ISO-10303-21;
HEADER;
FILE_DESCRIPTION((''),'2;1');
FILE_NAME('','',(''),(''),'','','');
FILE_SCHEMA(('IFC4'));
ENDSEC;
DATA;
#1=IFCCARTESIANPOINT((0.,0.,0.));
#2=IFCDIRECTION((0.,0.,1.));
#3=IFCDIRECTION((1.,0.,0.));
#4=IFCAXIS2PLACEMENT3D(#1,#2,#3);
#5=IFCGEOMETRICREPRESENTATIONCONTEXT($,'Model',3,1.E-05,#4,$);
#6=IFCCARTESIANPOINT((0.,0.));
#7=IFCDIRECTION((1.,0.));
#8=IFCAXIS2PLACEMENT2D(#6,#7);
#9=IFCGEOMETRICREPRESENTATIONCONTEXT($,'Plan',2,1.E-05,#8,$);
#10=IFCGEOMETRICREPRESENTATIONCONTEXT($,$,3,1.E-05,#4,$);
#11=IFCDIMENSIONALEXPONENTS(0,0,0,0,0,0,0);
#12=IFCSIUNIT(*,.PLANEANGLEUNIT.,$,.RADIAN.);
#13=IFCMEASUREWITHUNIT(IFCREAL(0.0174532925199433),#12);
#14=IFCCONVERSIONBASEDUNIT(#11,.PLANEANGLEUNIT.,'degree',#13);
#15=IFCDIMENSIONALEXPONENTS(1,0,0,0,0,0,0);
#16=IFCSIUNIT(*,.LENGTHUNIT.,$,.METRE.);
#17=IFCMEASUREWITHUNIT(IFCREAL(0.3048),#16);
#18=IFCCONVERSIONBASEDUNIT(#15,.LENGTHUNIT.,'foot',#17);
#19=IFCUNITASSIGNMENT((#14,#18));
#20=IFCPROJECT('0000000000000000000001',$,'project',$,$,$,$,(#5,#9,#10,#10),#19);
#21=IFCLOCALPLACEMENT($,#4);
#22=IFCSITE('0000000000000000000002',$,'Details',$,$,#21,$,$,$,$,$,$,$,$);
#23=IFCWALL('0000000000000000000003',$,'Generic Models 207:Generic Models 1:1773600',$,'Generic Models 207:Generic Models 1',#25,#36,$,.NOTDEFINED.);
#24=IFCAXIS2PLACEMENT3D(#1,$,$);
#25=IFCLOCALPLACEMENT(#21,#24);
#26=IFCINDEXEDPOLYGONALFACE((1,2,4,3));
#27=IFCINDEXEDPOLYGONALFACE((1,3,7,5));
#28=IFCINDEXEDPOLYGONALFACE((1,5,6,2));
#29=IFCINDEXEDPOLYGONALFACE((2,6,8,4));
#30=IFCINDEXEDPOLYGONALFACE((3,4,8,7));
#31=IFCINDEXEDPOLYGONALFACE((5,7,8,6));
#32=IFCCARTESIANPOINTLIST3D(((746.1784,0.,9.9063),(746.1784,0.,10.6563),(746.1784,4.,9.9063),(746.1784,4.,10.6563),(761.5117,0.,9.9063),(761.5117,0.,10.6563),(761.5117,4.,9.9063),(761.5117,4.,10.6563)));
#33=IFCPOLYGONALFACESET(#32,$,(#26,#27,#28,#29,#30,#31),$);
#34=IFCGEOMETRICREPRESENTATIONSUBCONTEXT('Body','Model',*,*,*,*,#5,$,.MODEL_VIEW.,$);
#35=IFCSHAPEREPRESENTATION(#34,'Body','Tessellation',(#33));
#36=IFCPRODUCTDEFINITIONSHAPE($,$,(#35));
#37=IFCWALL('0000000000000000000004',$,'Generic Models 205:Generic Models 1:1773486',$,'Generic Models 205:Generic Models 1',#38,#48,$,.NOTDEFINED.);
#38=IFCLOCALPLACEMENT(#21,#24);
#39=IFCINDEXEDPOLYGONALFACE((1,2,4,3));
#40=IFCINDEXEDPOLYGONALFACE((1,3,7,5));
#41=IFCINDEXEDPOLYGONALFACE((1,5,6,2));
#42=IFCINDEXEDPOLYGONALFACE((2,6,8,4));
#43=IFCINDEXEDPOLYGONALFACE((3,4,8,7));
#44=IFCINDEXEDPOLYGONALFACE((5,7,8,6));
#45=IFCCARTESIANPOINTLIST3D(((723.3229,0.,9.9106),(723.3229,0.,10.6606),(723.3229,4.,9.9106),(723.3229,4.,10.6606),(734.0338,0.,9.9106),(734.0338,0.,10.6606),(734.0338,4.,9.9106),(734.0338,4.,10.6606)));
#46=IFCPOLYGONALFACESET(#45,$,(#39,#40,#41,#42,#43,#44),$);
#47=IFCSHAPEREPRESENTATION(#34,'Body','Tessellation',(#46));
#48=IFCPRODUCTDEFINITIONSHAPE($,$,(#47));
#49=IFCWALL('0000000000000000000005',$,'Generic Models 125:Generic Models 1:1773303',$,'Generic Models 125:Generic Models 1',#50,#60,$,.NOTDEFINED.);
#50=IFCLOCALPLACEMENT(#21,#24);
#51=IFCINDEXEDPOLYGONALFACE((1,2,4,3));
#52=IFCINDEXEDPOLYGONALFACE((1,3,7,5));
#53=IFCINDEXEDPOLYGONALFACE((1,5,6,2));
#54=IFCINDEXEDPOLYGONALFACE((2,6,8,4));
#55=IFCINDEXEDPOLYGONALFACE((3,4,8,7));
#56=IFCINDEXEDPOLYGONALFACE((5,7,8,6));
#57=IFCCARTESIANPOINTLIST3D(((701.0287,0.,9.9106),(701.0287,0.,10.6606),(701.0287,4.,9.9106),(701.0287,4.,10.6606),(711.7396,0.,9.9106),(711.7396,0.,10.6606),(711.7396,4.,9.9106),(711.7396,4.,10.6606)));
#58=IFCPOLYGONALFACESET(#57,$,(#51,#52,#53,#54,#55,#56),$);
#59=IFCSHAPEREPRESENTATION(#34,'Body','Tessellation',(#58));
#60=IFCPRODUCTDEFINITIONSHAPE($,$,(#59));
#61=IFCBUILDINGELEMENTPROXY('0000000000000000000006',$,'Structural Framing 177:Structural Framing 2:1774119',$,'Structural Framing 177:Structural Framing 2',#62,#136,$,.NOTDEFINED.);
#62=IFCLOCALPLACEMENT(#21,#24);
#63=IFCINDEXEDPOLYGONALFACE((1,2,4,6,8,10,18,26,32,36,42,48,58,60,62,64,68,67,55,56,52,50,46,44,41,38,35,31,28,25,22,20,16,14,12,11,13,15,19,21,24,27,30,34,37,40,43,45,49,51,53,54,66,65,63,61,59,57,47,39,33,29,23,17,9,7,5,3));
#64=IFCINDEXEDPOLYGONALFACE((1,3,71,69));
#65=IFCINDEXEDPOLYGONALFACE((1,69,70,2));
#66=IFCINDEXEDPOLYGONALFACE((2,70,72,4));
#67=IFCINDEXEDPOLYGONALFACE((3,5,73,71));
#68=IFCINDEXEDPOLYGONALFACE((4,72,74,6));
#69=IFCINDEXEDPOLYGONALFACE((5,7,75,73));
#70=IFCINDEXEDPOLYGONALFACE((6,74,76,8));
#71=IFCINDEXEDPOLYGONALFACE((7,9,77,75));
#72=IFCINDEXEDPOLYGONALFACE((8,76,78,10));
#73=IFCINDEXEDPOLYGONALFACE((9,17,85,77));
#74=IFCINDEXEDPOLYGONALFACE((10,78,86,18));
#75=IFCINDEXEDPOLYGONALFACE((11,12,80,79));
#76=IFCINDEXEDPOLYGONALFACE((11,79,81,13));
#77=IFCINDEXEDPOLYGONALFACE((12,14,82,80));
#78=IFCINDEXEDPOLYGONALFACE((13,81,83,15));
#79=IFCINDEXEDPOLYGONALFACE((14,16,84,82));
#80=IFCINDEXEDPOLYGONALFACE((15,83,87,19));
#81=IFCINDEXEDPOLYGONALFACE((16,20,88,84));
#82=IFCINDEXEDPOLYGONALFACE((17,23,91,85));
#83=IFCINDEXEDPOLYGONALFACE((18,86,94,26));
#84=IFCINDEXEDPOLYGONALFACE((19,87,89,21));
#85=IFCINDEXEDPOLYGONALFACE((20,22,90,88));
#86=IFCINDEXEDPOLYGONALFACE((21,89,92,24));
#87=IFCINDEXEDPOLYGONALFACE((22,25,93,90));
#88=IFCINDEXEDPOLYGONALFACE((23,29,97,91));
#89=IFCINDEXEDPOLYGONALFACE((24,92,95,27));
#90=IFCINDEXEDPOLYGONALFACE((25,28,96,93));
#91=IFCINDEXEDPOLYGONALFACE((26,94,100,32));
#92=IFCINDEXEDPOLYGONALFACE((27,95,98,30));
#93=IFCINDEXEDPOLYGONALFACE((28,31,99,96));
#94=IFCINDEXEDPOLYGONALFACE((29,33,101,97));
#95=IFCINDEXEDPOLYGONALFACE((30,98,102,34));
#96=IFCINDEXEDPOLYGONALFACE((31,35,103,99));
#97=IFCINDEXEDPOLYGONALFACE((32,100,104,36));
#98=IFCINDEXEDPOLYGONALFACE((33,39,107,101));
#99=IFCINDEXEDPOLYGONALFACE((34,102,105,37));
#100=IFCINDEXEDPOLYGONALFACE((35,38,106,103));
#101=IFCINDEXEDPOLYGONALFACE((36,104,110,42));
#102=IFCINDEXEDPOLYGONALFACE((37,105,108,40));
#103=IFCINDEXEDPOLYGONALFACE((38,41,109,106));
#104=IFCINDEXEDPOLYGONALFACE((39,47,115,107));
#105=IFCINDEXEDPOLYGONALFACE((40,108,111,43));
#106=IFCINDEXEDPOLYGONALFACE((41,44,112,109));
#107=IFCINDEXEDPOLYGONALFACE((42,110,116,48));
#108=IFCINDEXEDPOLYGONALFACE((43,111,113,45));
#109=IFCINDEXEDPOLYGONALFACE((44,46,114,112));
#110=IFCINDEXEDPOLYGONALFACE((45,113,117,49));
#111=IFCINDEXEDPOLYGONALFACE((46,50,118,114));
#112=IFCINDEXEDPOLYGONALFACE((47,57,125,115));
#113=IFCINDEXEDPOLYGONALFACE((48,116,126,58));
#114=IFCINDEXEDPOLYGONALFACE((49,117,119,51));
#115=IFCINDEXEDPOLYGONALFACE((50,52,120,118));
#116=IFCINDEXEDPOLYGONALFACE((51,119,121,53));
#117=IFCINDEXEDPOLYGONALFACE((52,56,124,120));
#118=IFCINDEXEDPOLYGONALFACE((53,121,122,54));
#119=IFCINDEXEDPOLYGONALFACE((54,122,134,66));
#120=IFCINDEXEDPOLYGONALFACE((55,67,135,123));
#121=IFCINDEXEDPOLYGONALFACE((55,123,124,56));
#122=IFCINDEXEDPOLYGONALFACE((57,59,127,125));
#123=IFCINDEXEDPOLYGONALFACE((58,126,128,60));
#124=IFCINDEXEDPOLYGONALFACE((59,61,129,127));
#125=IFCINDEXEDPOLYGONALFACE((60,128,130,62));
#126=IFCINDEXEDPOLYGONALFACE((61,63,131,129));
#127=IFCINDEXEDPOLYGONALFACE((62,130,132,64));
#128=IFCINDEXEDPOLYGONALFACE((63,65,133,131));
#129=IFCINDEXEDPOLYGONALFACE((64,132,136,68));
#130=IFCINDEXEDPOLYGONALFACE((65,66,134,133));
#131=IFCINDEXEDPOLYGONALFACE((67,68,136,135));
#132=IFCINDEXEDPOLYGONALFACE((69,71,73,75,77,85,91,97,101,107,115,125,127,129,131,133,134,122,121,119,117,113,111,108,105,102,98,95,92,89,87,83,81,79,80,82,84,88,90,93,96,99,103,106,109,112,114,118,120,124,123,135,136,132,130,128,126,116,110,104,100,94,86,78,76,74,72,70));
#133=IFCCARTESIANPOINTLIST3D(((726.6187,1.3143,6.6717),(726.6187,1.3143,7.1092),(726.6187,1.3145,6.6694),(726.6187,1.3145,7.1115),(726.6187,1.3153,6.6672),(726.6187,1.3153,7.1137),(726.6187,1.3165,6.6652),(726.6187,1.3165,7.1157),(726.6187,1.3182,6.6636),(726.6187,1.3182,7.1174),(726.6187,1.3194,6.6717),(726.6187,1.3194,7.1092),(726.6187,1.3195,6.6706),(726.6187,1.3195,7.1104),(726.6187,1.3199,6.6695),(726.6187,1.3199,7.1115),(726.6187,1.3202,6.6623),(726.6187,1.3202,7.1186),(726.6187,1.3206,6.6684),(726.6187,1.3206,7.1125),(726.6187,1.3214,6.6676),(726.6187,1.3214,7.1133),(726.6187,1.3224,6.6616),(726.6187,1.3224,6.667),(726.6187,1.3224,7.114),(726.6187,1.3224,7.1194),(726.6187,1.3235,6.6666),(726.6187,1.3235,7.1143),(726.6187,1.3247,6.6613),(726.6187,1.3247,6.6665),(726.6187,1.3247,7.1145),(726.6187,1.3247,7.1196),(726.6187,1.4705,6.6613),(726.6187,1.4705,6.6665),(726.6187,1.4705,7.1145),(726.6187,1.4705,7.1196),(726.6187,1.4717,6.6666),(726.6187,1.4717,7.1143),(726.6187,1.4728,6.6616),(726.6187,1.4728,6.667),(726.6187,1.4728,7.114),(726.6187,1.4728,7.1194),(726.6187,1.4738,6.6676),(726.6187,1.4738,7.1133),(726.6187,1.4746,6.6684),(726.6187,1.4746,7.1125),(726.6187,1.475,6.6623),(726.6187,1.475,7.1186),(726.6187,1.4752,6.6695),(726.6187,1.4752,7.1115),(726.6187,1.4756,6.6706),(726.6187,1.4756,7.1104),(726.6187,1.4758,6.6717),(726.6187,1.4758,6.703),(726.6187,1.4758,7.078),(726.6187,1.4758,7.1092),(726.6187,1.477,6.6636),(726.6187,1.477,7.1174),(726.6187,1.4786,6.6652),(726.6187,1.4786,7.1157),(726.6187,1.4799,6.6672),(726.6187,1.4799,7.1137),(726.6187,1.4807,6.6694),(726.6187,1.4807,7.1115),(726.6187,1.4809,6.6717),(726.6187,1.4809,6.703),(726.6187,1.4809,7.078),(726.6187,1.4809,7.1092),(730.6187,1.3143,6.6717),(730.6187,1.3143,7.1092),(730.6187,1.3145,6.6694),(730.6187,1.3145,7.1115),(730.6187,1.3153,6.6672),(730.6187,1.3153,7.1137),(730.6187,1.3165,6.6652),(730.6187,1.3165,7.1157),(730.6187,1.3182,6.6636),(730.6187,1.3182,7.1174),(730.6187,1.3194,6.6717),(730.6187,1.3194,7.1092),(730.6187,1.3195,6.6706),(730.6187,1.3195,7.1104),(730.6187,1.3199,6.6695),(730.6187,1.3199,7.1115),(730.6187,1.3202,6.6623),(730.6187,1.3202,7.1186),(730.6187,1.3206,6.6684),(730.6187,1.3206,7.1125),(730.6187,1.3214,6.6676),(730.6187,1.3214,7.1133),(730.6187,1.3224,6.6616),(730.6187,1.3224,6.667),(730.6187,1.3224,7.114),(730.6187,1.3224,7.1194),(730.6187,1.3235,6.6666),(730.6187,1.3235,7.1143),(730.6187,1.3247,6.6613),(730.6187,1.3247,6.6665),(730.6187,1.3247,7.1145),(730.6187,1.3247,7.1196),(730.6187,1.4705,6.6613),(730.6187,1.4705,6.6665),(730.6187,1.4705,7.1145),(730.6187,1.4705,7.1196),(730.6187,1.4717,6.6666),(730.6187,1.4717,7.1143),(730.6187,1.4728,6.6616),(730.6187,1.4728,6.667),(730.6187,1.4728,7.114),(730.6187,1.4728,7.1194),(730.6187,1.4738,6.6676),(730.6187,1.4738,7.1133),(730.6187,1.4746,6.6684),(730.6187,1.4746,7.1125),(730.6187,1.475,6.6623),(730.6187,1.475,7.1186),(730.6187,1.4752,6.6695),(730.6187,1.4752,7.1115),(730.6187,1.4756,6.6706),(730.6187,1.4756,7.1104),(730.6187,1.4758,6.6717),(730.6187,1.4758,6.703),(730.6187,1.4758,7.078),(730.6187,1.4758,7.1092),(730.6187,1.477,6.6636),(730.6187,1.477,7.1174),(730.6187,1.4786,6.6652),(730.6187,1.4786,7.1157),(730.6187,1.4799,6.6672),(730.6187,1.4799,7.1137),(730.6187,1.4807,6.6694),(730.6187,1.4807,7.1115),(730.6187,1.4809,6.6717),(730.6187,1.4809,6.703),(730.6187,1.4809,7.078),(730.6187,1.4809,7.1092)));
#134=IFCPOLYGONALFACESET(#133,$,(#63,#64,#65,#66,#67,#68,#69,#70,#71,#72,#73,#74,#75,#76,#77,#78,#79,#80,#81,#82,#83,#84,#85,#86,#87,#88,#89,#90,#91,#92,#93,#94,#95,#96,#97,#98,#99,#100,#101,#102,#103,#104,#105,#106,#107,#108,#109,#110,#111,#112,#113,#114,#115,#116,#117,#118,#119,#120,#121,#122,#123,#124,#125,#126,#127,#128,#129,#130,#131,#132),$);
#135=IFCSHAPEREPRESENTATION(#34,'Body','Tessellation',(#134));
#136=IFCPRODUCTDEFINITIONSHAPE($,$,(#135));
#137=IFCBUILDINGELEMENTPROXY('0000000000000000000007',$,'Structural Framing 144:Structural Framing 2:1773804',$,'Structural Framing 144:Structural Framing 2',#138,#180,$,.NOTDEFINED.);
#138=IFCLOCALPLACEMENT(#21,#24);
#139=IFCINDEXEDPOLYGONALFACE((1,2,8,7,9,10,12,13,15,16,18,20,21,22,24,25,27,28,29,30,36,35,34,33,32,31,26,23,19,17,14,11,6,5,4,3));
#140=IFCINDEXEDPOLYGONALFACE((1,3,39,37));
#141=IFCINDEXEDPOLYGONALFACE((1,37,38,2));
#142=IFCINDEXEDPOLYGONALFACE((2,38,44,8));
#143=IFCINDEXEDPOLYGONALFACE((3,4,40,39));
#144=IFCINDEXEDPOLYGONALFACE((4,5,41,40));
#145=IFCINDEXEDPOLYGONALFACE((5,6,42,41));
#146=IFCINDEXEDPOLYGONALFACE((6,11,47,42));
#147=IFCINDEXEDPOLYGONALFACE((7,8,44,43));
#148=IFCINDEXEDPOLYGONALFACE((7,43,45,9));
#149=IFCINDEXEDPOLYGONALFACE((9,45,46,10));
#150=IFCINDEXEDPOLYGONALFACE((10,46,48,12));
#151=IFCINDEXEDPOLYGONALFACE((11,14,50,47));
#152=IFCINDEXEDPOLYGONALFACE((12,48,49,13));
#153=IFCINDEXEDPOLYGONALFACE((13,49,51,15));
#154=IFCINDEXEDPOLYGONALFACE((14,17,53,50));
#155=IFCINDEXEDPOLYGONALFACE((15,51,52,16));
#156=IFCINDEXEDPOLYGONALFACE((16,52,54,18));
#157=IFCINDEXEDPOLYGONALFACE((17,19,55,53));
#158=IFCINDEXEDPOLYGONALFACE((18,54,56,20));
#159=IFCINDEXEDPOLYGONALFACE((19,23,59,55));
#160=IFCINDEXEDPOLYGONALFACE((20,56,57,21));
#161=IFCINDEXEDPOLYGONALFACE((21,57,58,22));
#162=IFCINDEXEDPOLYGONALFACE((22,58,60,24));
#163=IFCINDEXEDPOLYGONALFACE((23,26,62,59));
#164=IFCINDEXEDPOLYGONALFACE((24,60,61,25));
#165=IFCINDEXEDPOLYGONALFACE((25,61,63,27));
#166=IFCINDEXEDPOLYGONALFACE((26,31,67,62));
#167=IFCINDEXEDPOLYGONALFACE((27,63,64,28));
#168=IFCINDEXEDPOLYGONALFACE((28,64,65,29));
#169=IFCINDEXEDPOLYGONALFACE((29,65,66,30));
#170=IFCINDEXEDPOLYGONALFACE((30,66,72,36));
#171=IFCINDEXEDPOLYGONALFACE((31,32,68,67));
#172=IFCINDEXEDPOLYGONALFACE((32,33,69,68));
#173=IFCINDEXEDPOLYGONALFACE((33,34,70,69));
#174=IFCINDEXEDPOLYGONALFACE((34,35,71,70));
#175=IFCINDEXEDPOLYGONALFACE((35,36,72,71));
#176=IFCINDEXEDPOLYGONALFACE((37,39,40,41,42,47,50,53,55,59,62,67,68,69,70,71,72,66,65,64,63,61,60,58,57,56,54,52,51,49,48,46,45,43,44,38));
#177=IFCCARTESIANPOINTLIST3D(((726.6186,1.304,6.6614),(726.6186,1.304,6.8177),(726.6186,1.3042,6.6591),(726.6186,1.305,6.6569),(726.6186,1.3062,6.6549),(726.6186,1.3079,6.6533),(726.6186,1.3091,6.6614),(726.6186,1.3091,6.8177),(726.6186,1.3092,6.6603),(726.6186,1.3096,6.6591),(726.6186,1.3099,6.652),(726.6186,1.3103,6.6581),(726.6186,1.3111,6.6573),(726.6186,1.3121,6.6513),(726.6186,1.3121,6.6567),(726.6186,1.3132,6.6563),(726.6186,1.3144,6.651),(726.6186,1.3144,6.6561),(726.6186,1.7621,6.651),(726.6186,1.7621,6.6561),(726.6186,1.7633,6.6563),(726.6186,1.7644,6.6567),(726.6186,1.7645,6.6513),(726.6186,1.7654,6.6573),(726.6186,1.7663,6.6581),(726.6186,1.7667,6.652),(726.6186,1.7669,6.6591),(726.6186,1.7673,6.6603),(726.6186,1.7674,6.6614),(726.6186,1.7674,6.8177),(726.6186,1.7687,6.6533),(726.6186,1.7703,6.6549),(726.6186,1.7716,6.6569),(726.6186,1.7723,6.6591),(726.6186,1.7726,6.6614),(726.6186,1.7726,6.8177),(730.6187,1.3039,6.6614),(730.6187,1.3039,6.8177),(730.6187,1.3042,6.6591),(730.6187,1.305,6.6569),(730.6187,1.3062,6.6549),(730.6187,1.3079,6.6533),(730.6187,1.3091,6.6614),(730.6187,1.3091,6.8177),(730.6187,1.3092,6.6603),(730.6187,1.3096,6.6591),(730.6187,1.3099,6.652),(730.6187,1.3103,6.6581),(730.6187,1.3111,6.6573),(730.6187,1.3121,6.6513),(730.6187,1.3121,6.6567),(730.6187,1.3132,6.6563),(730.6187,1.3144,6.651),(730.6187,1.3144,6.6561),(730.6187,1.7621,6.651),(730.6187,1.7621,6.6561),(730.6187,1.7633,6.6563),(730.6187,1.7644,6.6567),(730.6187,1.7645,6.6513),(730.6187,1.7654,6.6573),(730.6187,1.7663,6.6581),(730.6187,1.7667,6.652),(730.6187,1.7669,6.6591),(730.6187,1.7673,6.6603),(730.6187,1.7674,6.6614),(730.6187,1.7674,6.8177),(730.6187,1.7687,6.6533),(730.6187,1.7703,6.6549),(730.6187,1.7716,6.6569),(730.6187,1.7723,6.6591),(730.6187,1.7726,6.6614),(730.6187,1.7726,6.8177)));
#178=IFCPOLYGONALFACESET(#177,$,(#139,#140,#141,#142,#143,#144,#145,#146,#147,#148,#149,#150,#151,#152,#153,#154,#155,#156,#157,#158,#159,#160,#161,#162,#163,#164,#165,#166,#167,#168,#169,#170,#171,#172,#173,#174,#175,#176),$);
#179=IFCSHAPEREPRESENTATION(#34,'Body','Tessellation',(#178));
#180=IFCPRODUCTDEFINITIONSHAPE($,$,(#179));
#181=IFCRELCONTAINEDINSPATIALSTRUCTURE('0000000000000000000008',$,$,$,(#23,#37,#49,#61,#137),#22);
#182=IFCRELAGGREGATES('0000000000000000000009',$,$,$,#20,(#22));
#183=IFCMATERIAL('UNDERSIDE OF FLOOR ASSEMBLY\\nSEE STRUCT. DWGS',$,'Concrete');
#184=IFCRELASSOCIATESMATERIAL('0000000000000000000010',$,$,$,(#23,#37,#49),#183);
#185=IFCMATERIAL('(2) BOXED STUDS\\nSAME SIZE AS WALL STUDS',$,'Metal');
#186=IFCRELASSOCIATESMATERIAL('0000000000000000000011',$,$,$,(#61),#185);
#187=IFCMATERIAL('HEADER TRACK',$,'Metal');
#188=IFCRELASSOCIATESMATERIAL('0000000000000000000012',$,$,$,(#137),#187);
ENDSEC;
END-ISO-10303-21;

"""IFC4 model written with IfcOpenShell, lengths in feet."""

from ifc_helpers import new_model, entity, si_unit, converted_unit, frame, origin_with_axes, origin_2d_with_axis, place, context, subcontext, project, spatial, polyline, rectangle, outline, extrude, material, element, save


model = new_model("IFC4")

# Units and contexts
model_context = context("Model", 3, precision=1e-05, world=origin_with_axes())
plan_context = context("Plan", 2, precision=1e-05, world=origin_2d_with_axis())
context_of_model = context(None, 3, precision=1e-05, world=origin_with_axes())
body_context = subcontext(model_context, "Body", "Model", "MODEL_VIEW")
ifc_project = project(units=[converted_unit("PLANEANGLEUNIT", "degree", entity("IfcReal", 0.0174532925199433), si_unit("PLANEANGLEUNIT", "RADIAN"), dimensions=[0, 0, 0, 0, 0, 0, 0]), converted_unit("LENGTHUNIT", "foot", entity("IfcReal", 0.3048), si_unit("LENGTHUNIT", "METRE"), dimensions=[1, 0, 0, 0, 0, 0, 0])], contexts=[model_context, plan_context, context_of_model, context_of_model])

# Site
site_placement = place(None, origin_with_axes())
site = spatial("IfcSite", under=ifc_project, at=site_placement, Name="Details")

# Walls
ifc_material_1 = material(Name="UNDERSIDE OF FLOOR ASSEMBLY\\nSEE STRUCT. DWGS", Category="Concrete")
wall_1_placement = place(site_placement, frame((746.1784, 0.0, 9.9063), z_axis=(0.0, 0.0, 1.0), x_axis=(1.0, 0.0, 0.0)))
element("IfcWall", 1, at=wall_1_placement, inside=site, material=ifc_material_1, Name="Generic Models 207:Generic Models 1:1773600", ObjectType="Generic Models 207:Generic Models 1", PredefinedType="NOTDEFINED", context=body_context, shape_type="SweptSolid", body=[
    extrude(rectangle(XDim=4.0, YDim=15.3333, at=origin_2d_with_axis()), frame((7.6667, 2.0, 0.0), z_axis=(0.0, 0.0, 1.0), x_axis=(0.0, 1.0, 0.0)), (0.0, 0.0, 1.0), 0.75),
])
wall_2_placement = place(site_placement, frame((723.3229, 0.0, 9.9106), z_axis=(0.0, 0.0, 1.0), x_axis=(1.0, 0.0, 0.0)))
element("IfcWall", 2, at=wall_2_placement, inside=site, material=ifc_material_1, Name="Generic Models 205:Generic Models 1:1773486", ObjectType="Generic Models 205:Generic Models 1", PredefinedType="NOTDEFINED", context=body_context, shape_type="SweptSolid", body=[
    extrude(rectangle(XDim=4.0, YDim=10.7109, at=origin_2d_with_axis()), frame((5.3554, 2.0, 0.0), z_axis=(0.0, 0.0, 1.0), x_axis=(0.0, 1.0, 0.0)), (0.0, 0.0, 1.0), 0.75),
])
wall_3_placement = place(site_placement, frame((701.0287, 0.0, 9.9106), z_axis=(0.0, 0.0, 1.0), x_axis=(1.0, 0.0, 0.0)))
element("IfcWall", 3, at=wall_3_placement, inside=site, material=ifc_material_1, Name="Generic Models 125:Generic Models 1:1773303", ObjectType="Generic Models 125:Generic Models 1", PredefinedType="NOTDEFINED", context=body_context, shape_type="SweptSolid", body=[
    extrude(rectangle(XDim=4.0, YDim=10.7109, at=origin_2d_with_axis()), frame((5.3554, 2.0, 0.0), z_axis=(0.0, 0.0, 1.0), x_axis=(0.0, 1.0, 0.0)), (0.0, 0.0, 1.0), 0.75),
])

# Building element proxies
ifc_material_2 = material(Name="HEADER TRACK", Category="Metal")
ifc_material_3 = material(Name="(2) BOXED STUDS\\nSAME SIZE AS WALL STUDS", Category="Metal")
proxy_1_placement = place(site_placement, frame((728.6186, 1.3616, 6.8905), z_axis=(1.0, 0.0, 0.0), x_axis=(0.0, 0.0, -1.0)))
element("IfcBuildingElementProxy", 4, at=proxy_1_placement, inside=site, material=ifc_material_3, Name="Structural Framing 177:Structural Framing 2:1774119", ObjectType="Structural Framing 177:Structural Framing 2", PredefinedType="NOTDEFINED", context=body_context, shape_type="SweptSolid", body=[
    extrude(outline(polyline([(-0.0681, 0.224), (0.0776, 0.224), (0.0788, 0.2239), (0.0799, 0.2235), (0.0809, 0.2229), (0.0818, 0.222), (0.0824, 0.221), (0.0828, 0.2199), (0.0829, 0.2187), (0.0829, -0.2187), (0.0828, -0.2199), (0.0824, -0.221), (0.0818, -0.222), (0.0809, -0.2229), (0.0799, -0.2235), (0.0788, -0.2239), (0.0776, -0.224), (-0.0681, -0.224), (-0.0693, -0.2239), (-0.0704, -0.2235), (-0.0714, -0.2229), (-0.0723, -0.222), (-0.0729, -0.221), (-0.0733, -0.2199), (-0.0734, -0.2187), (-0.0734, -0.1875), (-0.0786, -0.1875), (-0.0786, -0.2187), (-0.0783, -0.221), (-0.0775, -0.2233), (-0.0763, -0.2252), (-0.0746, -0.2269), (-0.0727, -0.2281), (-0.0705, -0.2289), (-0.0681, -0.2292), (0.0776, -0.2292), (0.08, -0.2289), (0.0822, -0.2281), (0.0842, -0.2269), (0.0858, -0.2252), (0.087, -0.2233), (0.0878, -0.221), (0.0881, -0.2187), (0.0881, 0.2187), (0.0878, 0.221), (0.087, 0.2233), (0.0858, 0.2252), (0.0842, 0.2269), (0.0822, 0.2281), (0.08, 0.2289), (0.0776, 0.2292), (-0.0681, 0.2292), (-0.0705, 0.2289), (-0.0727, 0.2281), (-0.0746, 0.2269), (-0.0763, 0.2252), (-0.0775, 0.2233), (-0.0783, 0.221), (-0.0786, 0.2187), (-0.0786, 0.1875), (-0.0734, 0.1875), (-0.0734, 0.2187), (-0.0733, 0.2199), (-0.0729, 0.221), (-0.0723, 0.222), (-0.0714, 0.2229), (-0.0704, 0.2235), (-0.0693, 0.2239), (-0.0681, 0.224)])), frame((0.0, 0.0408, -2.0), z_axis=(0.000001, 0.0, -1.0), x_axis=(0.0, -1.0, 0.0)), (0.0, -0.000001, -1.0), 4.0),
])
proxy_2_placement = place(site_placement, frame((728.6187, 1.5383, 6.6879), z_axis=(1.0, 0.0, 0.0), x_axis=(0.0, 0.0, -1.0)))
element("IfcBuildingElementProxy", 5, at=proxy_2_placement, inside=site, material=ifc_material_2, Name="Structural Framing 144:Structural Framing 2:1773804", ObjectType="Structural Framing 144:Structural Framing 2", PredefinedType="NOTDEFINED", context=body_context, shape_type="SweptSolid", body=[
    extrude(outline(polyline([(0.2269, 0.0), (0.2258, -0.0005), (0.2246, -0.0007), (-0.2217, -0.0359), (-0.2229, -0.0358), (-0.2241, -0.0355), (-0.2251, -0.035), (-0.226, -0.0342), (-0.2267, -0.0332), (-0.2272, -0.0322), (-0.2274, -0.031), (-0.2397, 0.1247), (-0.2448, 0.1243), (-0.2326, -0.0314), (-0.2321, -0.0337), (-0.2312, -0.0358), (-0.2298, -0.0377), (-0.228, -0.0392), (-0.2259, -0.0403), (-0.2237, -0.0409), (-0.2213, -0.041), (0.225, -0.0058), (0.2273, -0.0054), (0.2295, -0.0045), (0.2313, -0.0031), (0.2329, -0.0013), (0.2339, 0.0008), (0.2345, 0.0031), (0.2346, 0.0054), (0.2224, 0.1611), (0.2172, 0.1607), (0.2295, 0.005), (0.2294, 0.0038), (0.2291, 0.0027), (0.2286, 0.0016), (0.2278, 0.0007), (0.2269, 0.0)])), frame((0.0134, 0.0, -2.0001), z_axis=(-0.000039, 0.0, -1.0), x_axis=(0.078499, -0.996914, -0.000003)), (-0.000003, 0.000039, -1.0), 4.0),
])

save(model, "model.ifc")
